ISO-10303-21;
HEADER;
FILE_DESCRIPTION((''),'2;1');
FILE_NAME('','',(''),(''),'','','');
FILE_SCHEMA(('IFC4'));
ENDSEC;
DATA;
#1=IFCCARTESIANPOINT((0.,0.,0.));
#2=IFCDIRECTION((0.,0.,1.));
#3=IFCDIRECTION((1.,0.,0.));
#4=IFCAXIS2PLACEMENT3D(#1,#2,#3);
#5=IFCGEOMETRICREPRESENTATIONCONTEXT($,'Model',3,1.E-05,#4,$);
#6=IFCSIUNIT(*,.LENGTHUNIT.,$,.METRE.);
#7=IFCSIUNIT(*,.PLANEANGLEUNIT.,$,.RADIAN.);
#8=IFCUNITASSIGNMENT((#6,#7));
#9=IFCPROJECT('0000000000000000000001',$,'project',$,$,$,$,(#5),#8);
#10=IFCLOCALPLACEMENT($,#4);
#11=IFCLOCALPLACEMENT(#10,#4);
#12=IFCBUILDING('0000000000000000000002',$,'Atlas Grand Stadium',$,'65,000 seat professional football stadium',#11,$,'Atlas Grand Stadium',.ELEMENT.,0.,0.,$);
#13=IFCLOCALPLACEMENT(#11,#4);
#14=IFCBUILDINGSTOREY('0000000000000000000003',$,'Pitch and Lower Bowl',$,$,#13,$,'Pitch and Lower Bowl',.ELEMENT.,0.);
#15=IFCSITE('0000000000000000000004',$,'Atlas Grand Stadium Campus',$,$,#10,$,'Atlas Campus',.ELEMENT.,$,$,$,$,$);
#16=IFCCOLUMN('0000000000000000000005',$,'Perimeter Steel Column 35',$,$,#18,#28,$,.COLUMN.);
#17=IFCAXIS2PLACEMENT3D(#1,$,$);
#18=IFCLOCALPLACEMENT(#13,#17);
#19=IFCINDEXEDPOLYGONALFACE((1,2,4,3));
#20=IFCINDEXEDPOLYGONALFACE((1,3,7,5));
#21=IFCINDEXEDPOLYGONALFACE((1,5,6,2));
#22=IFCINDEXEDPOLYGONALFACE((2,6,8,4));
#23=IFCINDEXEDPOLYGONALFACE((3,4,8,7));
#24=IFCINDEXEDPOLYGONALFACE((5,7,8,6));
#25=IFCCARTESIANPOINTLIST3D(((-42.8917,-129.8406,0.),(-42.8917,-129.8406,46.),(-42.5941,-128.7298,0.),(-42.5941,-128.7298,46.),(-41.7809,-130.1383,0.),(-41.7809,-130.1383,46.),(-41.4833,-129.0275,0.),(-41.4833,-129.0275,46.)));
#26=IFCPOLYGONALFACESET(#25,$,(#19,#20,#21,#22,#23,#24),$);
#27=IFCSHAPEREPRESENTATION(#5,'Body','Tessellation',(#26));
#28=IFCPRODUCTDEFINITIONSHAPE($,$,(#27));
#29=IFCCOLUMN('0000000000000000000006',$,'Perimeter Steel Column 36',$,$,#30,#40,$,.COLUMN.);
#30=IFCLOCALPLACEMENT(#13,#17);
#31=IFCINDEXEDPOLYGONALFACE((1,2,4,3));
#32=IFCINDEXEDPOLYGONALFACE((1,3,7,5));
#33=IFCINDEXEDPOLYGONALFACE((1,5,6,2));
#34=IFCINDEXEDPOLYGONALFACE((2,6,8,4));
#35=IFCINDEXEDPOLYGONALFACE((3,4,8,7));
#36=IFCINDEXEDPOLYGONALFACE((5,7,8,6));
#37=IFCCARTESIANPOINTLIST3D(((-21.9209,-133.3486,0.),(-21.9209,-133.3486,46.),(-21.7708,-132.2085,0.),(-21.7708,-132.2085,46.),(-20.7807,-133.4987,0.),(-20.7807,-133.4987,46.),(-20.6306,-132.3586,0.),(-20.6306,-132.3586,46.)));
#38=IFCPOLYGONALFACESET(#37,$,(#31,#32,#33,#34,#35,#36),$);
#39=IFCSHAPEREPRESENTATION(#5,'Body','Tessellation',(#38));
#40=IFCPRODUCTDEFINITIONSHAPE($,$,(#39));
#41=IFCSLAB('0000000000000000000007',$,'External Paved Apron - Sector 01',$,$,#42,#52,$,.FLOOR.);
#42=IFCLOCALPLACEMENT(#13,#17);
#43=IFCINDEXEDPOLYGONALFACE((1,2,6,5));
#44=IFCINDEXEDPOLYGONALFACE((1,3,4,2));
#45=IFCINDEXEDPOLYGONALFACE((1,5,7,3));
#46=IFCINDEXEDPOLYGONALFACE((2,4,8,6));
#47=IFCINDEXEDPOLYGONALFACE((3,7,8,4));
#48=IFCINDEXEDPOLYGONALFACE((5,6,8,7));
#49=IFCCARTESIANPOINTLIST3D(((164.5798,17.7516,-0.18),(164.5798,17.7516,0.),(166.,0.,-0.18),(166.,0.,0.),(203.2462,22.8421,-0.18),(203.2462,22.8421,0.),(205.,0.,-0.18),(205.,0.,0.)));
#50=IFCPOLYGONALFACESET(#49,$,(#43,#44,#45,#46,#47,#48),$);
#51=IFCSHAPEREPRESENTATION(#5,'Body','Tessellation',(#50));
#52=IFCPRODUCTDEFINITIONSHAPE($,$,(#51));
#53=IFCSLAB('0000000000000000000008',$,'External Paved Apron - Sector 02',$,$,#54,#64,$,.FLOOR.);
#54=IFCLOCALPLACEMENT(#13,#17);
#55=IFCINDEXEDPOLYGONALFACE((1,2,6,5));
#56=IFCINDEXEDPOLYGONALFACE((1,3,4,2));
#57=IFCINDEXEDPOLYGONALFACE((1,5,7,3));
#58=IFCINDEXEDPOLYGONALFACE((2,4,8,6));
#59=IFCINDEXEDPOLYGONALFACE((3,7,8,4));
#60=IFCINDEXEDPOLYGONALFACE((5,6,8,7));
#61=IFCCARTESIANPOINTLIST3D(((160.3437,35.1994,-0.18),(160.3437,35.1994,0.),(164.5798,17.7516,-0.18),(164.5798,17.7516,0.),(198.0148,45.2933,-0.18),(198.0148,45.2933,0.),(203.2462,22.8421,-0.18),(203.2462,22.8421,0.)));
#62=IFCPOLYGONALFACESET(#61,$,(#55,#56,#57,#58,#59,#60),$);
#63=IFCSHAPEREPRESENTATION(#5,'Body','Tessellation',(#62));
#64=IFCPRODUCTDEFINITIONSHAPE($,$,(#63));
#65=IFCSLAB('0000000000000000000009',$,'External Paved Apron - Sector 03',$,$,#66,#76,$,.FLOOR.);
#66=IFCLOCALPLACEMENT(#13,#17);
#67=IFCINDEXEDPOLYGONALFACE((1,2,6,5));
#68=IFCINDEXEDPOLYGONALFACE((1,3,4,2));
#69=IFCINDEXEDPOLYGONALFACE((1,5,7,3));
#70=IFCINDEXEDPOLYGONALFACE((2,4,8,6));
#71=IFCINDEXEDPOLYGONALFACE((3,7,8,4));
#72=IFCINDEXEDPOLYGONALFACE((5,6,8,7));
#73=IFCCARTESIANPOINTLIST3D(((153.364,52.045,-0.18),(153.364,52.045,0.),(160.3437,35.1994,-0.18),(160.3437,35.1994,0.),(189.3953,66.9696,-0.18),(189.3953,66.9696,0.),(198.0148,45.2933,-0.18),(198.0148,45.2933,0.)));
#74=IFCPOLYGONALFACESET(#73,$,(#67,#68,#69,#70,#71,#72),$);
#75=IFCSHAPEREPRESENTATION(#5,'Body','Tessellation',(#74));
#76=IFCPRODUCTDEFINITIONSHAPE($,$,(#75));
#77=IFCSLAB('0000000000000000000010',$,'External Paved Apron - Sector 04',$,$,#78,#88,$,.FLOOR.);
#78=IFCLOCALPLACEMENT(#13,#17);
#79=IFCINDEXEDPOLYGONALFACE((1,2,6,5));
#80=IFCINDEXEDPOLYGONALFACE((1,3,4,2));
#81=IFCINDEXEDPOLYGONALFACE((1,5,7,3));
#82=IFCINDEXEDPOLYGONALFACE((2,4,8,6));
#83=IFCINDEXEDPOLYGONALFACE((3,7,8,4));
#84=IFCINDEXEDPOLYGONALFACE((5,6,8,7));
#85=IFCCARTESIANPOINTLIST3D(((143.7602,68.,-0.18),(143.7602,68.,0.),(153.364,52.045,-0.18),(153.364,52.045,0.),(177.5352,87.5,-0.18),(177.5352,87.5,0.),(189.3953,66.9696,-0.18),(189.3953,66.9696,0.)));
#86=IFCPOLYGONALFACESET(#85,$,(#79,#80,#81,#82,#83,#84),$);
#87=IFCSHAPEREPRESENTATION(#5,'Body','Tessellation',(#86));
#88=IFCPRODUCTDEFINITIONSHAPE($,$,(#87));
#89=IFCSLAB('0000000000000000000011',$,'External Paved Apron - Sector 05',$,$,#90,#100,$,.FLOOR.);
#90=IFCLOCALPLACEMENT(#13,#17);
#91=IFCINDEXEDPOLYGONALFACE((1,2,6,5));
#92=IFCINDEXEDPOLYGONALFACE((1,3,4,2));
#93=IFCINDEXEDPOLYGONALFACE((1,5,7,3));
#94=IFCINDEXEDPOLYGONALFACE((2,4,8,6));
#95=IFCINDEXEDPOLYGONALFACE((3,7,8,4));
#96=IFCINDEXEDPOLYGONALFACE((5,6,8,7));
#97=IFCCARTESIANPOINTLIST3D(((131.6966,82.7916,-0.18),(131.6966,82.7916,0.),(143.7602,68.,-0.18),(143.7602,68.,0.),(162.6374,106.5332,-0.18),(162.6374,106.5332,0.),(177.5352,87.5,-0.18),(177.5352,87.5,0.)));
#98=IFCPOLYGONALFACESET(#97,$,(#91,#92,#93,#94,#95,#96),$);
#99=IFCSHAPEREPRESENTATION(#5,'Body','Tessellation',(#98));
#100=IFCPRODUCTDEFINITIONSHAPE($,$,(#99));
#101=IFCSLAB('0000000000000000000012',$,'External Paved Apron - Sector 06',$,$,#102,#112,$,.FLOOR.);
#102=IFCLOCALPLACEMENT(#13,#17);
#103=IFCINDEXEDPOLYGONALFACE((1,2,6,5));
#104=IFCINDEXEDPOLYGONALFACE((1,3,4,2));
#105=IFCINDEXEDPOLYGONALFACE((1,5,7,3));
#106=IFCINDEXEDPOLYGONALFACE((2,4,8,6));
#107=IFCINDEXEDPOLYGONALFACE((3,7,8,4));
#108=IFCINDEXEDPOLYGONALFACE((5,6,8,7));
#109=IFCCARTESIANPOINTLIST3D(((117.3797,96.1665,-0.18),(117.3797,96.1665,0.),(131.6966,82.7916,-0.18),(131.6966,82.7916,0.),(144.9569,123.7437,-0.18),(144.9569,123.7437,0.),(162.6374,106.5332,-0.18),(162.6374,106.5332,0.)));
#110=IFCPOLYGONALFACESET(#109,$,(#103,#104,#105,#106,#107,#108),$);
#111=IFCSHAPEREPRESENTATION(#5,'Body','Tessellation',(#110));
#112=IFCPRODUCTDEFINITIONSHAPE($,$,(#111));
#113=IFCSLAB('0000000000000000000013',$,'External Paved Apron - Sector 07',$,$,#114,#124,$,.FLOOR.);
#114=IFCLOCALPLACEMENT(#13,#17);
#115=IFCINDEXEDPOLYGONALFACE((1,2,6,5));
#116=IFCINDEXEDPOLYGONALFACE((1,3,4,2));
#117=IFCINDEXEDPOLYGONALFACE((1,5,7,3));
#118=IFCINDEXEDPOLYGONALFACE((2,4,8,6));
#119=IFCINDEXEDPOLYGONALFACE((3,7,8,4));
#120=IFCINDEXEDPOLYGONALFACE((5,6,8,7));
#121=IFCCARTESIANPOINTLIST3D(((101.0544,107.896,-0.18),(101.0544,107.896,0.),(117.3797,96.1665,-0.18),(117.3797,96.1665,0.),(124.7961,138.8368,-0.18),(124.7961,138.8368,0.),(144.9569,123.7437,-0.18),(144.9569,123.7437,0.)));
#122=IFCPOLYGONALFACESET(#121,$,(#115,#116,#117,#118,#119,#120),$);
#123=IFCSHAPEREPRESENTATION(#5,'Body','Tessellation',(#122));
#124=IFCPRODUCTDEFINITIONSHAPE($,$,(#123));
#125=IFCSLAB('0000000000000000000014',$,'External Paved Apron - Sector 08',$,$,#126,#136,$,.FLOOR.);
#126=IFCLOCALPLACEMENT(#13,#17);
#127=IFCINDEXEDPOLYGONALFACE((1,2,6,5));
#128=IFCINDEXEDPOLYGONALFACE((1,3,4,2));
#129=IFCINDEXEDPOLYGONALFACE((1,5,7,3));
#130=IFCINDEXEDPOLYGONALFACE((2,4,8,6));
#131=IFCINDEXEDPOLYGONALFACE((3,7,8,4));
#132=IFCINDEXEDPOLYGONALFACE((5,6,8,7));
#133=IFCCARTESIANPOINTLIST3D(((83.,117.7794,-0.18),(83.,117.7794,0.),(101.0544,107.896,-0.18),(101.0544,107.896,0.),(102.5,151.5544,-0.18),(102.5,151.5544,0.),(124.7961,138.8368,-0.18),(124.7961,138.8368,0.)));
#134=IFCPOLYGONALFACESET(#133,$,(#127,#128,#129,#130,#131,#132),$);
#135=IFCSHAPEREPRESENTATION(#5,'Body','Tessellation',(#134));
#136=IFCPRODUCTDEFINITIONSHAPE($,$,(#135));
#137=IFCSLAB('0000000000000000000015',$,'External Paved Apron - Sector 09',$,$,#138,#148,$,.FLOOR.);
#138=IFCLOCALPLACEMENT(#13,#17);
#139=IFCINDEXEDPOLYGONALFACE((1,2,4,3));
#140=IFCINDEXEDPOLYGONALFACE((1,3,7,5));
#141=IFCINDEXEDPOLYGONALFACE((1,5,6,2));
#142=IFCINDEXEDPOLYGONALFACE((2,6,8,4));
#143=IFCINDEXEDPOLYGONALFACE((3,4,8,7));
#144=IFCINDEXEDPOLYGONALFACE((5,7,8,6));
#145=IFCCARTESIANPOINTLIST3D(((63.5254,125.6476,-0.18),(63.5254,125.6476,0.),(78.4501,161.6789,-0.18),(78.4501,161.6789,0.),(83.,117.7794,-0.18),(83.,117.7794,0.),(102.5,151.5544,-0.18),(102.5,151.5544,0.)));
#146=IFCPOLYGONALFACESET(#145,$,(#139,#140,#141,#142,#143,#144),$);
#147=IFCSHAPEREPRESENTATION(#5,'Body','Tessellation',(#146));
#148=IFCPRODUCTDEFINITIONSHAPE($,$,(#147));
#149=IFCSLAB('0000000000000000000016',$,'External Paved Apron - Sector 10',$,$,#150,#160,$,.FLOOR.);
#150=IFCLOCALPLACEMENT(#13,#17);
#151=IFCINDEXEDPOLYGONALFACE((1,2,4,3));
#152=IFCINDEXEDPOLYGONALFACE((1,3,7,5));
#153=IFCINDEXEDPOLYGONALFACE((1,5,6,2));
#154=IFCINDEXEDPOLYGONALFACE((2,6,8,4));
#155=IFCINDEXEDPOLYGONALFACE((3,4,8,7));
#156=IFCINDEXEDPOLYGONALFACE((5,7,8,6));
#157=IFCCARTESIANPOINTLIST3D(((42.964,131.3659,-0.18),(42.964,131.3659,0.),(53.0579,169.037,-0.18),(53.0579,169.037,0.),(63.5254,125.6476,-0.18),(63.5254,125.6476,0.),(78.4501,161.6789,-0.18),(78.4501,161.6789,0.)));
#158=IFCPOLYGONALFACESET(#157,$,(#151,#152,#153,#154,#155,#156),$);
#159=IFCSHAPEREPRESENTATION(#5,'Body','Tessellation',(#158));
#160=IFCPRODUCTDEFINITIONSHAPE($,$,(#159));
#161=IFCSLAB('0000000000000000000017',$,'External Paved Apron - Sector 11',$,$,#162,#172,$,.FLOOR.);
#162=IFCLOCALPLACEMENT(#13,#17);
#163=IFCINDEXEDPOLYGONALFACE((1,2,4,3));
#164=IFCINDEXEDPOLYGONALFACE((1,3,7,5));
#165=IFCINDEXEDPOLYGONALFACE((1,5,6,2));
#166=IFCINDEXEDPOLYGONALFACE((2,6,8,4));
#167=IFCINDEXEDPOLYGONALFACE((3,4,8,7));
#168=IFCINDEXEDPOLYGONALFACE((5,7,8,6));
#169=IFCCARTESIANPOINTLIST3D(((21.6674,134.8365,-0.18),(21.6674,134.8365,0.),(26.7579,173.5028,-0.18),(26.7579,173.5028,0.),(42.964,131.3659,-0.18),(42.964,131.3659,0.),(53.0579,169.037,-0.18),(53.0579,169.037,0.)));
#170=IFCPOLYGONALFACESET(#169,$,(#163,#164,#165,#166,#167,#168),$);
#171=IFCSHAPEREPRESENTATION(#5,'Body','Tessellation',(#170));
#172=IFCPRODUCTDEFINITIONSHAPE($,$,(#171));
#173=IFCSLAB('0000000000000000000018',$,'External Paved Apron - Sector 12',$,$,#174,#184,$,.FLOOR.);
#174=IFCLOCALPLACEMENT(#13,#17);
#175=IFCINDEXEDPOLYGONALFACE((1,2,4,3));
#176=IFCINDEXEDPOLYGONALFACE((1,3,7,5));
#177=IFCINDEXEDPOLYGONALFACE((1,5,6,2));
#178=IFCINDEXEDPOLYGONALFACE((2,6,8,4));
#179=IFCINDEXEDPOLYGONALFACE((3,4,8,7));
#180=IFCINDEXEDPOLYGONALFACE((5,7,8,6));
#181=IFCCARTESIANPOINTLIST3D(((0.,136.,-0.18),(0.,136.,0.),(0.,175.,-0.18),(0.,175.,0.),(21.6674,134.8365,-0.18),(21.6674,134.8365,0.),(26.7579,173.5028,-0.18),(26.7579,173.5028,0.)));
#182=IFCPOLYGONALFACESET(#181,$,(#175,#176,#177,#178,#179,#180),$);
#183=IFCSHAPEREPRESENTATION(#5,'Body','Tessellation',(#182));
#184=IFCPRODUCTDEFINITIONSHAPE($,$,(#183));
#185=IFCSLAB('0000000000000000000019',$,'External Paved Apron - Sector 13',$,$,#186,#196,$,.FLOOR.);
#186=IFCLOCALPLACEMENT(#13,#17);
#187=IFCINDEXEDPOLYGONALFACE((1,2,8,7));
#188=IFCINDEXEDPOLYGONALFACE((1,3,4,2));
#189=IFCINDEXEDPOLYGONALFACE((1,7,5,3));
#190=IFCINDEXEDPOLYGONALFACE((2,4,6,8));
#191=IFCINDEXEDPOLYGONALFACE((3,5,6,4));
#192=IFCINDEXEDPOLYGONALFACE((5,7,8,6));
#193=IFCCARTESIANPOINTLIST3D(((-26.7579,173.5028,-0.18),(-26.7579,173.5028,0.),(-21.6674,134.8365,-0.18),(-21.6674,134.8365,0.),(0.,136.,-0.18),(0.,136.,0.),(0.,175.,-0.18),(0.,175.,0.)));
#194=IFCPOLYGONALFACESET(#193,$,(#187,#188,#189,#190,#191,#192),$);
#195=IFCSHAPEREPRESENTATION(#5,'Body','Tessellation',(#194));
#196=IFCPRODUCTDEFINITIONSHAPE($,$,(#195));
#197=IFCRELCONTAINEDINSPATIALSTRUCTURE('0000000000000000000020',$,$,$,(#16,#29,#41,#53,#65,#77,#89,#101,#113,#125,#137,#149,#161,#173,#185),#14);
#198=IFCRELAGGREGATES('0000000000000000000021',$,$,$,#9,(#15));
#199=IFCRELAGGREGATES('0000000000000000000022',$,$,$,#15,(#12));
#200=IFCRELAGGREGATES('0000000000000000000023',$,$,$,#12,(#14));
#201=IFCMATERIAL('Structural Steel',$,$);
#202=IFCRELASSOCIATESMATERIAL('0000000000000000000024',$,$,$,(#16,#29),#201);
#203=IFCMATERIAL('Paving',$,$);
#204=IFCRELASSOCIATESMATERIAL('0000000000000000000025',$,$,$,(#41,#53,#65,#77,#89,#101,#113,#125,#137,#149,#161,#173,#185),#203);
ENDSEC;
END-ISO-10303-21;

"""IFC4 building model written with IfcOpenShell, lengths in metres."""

from ifc_helpers import new_model, si_unit, frame, origin_with_axes, origin_2d_with_axis, place, context, project, spatial, polyline, rectangle, outline, extrude, material, element, save


model = new_model("IFC4")

# Units and contexts
model_context = context("Model", 3, precision=1e-05, world=origin_with_axes())
ifc_project = project(units=[si_unit("LENGTHUNIT", "METRE"), si_unit("PLANEANGLEUNIT", "RADIAN")], contexts=[model_context])

# Site, building, storey
site_placement = place(None, origin_with_axes())
site = spatial("IfcSite", under=ifc_project, at=site_placement, Name="Atlas Grand Stadium Campus", LongName="Atlas Campus", CompositionType="ELEMENT")
building_placement = place(site_placement, origin_with_axes())
building = spatial("IfcBuilding", under=site, at=building_placement, Name="Atlas Grand Stadium", ObjectType="65,000 seat professional football stadium", LongName="Atlas Grand Stadium", CompositionType="ELEMENT", ElevationOfRefHeight=0.0, ElevationOfTerrain=0.0)
storey_placement = place(building_placement, origin_with_axes())
storey = spatial("IfcBuildingStorey", under=building, at=storey_placement, Name="Pitch and Lower Bowl", LongName="Pitch and Lower Bowl", CompositionType="ELEMENT", Elevation=0.0)

# Columns
ifc_material_1 = material(Name="Structural Steel")
for number, where, z_axis, x_axis, name in (
    (1, (-42.1875, -129.4341, 0.0), (0.0, 0.0, 1.0), (0.96593, -0.25882, 0.0), "Perimeter Steel Column 35"),
    (2, (-21.2758, -132.8536, 0.0), (0.0, 0.0, 1.0), (0.99144, -0.13053, 0.0), "Perimeter Steel Column 36"),
):
    element("IfcColumn", number, at=place(storey_placement, frame(where, z_axis=z_axis, x_axis=x_axis)), inside=storey, material=ifc_material_1, Name=name, PredefinedType="COLUMN", context=model_context, shape_type="SweptSolid", body=[
        extrude(rectangle(XDim=1.15, YDim=1.15, at=origin_2d_with_axis()), origin_with_axes(), (0.0, 0.0, 1.0), 46.0),
    ])

# Slabs
ifc_material_2 = material(Name="Paving")
slab_1_placement = place(storey_placement, frame((0.0, 0.0, -0.18), z_axis=(0.0, 0.0, 1.0), x_axis=(1.0, 0.0, 0.0)))
element("IfcSlab", 3, at=slab_1_placement, inside=storey, material=ifc_material_2, Name="External Paved Apron - Sector 01", PredefinedType="FLOOR", context=model_context, shape_type="SweptSolid", body=[
    extrude(outline(polyline([(205.0, 0.0), (203.2462, 22.8421), (164.5798, 17.7516), (166.0, 0.0), (205.0, 0.0)])), origin_with_axes(), (0.0, 0.0, 1.0), 0.18),
])
slab_2_placement = place(storey_placement, frame((0.0, 0.0, -0.18), z_axis=(0.0, 0.0, 1.0), x_axis=(1.0, 0.0, 0.0)))
element("IfcSlab", 4, at=slab_2_placement, inside=storey, material=ifc_material_2, Name="External Paved Apron - Sector 02", PredefinedType="FLOOR", context=model_context, shape_type="SweptSolid", body=[
    extrude(outline(polyline([(203.2462, 22.8421), (198.0148, 45.2933), (160.3437, 35.1994), (164.5798, 17.7516), (203.2462, 22.8421)])), origin_with_axes(), (0.0, 0.0, 1.0), 0.18),
])
slab_3_placement = place(storey_placement, frame((0.0, 0.0, -0.18), z_axis=(0.0, 0.0, 1.0), x_axis=(1.0, 0.0, 0.0)))
element("IfcSlab", 5, at=slab_3_placement, inside=storey, material=ifc_material_2, Name="External Paved Apron - Sector 03", PredefinedType="FLOOR", context=model_context, shape_type="SweptSolid", body=[
    extrude(outline(polyline([(198.0148, 45.2933), (189.3953, 66.9696), (153.364, 52.045), (160.3437, 35.1994), (198.0148, 45.2933)])), origin_with_axes(), (0.0, 0.0, 1.0), 0.18),
])
slab_4_placement = place(storey_placement, frame((0.0, 0.0, -0.18), z_axis=(0.0, 0.0, 1.0), x_axis=(1.0, 0.0, 0.0)))
element("IfcSlab", 6, at=slab_4_placement, inside=storey, material=ifc_material_2, Name="External Paved Apron - Sector 04", PredefinedType="FLOOR", context=model_context, shape_type="SweptSolid", body=[
    extrude(outline(polyline([(189.3953, 66.9696), (177.5352, 87.5), (143.7602, 68.0), (153.364, 52.045), (189.3953, 66.9696)])), origin_with_axes(), (0.0, 0.0, 1.0), 0.18),
])
slab_5_placement = place(storey_placement, frame((0.0, 0.0, -0.18), z_axis=(0.0, 0.0, 1.0), x_axis=(1.0, 0.0, 0.0)))
element("IfcSlab", 7, at=slab_5_placement, inside=storey, material=ifc_material_2, Name="External Paved Apron - Sector 05", PredefinedType="FLOOR", context=model_context, shape_type="SweptSolid", body=[
    extrude(outline(polyline([(177.5352, 87.5), (162.6374, 106.5332), (131.6967, 82.7916), (143.7602, 68.0), (177.5352, 87.5)])), origin_with_axes(), (0.0, 0.0, 1.0), 0.18),
])
slab_6_placement = place(storey_placement, frame((0.0, 0.0, -0.18), z_axis=(0.0, 0.0, 1.0), x_axis=(1.0, 0.0, 0.0)))
element("IfcSlab", 8, at=slab_6_placement, inside=storey, material=ifc_material_2, Name="External Paved Apron - Sector 06", PredefinedType="FLOOR", context=model_context, shape_type="SweptSolid", body=[
    extrude(outline(polyline([(162.6374, 106.5332), (144.9569, 123.7437), (117.3797, 96.1665), (131.6967, 82.7916), (162.6374, 106.5332)])), origin_with_axes(), (0.0, 0.0, 1.0), 0.18),
])
slab_7_placement = place(storey_placement, frame((0.0, 0.0, -0.18), z_axis=(0.0, 0.0, 1.0), x_axis=(1.0, 0.0, 0.0)))
element("IfcSlab", 9, at=slab_7_placement, inside=storey, material=ifc_material_2, Name="External Paved Apron - Sector 07", PredefinedType="FLOOR", context=model_context, shape_type="SweptSolid", body=[
    extrude(outline(polyline([(144.9569, 123.7437), (124.7961, 138.8368), (101.0544, 107.8961), (117.3797, 96.1665), (144.9569, 123.7437)])), origin_with_axes(), (0.0, 0.0, 1.0), 0.18),
])
slab_8_placement = place(storey_placement, frame((0.0, 0.0, -0.18), z_axis=(0.0, 0.0, 1.0), x_axis=(1.0, 0.0, 0.0)))
element("IfcSlab", 10, at=slab_8_placement, inside=storey, material=ifc_material_2, Name="External Paved Apron - Sector 08", PredefinedType="FLOOR", context=model_context, shape_type="SweptSolid", body=[
    extrude(outline(polyline([(124.7961, 138.8368), (102.5, 151.5545), (83.0, 117.7794), (101.0544, 107.8961), (124.7961, 138.8368)])), origin_with_axes(), (0.0, 0.0, 1.0), 0.18),
])
slab_9_placement = place(storey_placement, frame((0.0, 0.0, -0.18), z_axis=(0.0, 0.0, 1.0), x_axis=(1.0, 0.0, 0.0)))
element("IfcSlab", 11, at=slab_9_placement, inside=storey, material=ifc_material_2, Name="External Paved Apron - Sector 09", PredefinedType="FLOOR", context=model_context, shape_type="SweptSolid", body=[
    extrude(outline(polyline([(102.5, 151.5545), (78.4501, 161.6789), (63.5254, 125.6476), (83.0, 117.7794), (102.5, 151.5545)])), origin_with_axes(), (0.0, 0.0, 1.0), 0.18),
])
slab_10_placement = place(storey_placement, frame((0.0, 0.0, -0.18), z_axis=(0.0, 0.0, 1.0), x_axis=(1.0, 0.0, 0.0)))
element("IfcSlab", 12, at=slab_10_placement, inside=storey, material=ifc_material_2, Name="External Paved Apron - Sector 10", PredefinedType="FLOOR", context=model_context, shape_type="SweptSolid", body=[
    extrude(outline(polyline([(78.4501, 161.6789), (53.0579, 169.037), (42.964, 131.3659), (63.5254, 125.6476), (78.4501, 161.6789)])), origin_with_axes(), (0.0, 0.0, 1.0), 0.18),
])
slab_11_placement = place(storey_placement, frame((0.0, 0.0, -0.18), z_axis=(0.0, 0.0, 1.0), x_axis=(1.0, 0.0, 0.0)))
element("IfcSlab", 13, at=slab_11_placement, inside=storey, material=ifc_material_2, Name="External Paved Apron - Sector 11", PredefinedType="FLOOR", context=model_context, shape_type="SweptSolid", body=[
    extrude(outline(polyline([(53.0579, 169.037), (26.7579, 173.5028), (21.6673, 134.8365), (42.964, 131.3659), (53.0579, 169.037)])), origin_with_axes(), (0.0, 0.0, 1.0), 0.18),
])
slab_12_placement = place(storey_placement, frame((0.0, 0.0, -0.18), z_axis=(0.0, 0.0, 1.0), x_axis=(1.0, 0.0, 0.0)))
element("IfcSlab", 14, at=slab_12_placement, inside=storey, material=ifc_material_2, Name="External Paved Apron - Sector 12", PredefinedType="FLOOR", context=model_context, shape_type="SweptSolid", body=[
    extrude(outline(polyline([(26.7579, 173.5028), (0.0, 175.0), (0.0, 136.0), (21.6673, 134.8365), (26.7579, 173.5028)])), origin_with_axes(), (0.0, 0.0, 1.0), 0.18),
])
slab_13_placement = place(storey_placement, frame((0.0, 0.0, -0.18), z_axis=(0.0, 0.0, 1.0), x_axis=(1.0, 0.0, 0.0)))
element("IfcSlab", 15, at=slab_13_placement, inside=storey, material=ifc_material_2, Name="External Paved Apron - Sector 13", PredefinedType="FLOOR", context=model_context, shape_type="SweptSolid", body=[
    extrude(outline(polyline([(0.0, 175.0), (-26.7579, 173.5028), (-21.6673, 134.8365), (0.0, 136.0), (0.0, 175.0)])), origin_with_axes(), (0.0, 0.0, 1.0), 0.18),
])

save(model, "model.ifc")
